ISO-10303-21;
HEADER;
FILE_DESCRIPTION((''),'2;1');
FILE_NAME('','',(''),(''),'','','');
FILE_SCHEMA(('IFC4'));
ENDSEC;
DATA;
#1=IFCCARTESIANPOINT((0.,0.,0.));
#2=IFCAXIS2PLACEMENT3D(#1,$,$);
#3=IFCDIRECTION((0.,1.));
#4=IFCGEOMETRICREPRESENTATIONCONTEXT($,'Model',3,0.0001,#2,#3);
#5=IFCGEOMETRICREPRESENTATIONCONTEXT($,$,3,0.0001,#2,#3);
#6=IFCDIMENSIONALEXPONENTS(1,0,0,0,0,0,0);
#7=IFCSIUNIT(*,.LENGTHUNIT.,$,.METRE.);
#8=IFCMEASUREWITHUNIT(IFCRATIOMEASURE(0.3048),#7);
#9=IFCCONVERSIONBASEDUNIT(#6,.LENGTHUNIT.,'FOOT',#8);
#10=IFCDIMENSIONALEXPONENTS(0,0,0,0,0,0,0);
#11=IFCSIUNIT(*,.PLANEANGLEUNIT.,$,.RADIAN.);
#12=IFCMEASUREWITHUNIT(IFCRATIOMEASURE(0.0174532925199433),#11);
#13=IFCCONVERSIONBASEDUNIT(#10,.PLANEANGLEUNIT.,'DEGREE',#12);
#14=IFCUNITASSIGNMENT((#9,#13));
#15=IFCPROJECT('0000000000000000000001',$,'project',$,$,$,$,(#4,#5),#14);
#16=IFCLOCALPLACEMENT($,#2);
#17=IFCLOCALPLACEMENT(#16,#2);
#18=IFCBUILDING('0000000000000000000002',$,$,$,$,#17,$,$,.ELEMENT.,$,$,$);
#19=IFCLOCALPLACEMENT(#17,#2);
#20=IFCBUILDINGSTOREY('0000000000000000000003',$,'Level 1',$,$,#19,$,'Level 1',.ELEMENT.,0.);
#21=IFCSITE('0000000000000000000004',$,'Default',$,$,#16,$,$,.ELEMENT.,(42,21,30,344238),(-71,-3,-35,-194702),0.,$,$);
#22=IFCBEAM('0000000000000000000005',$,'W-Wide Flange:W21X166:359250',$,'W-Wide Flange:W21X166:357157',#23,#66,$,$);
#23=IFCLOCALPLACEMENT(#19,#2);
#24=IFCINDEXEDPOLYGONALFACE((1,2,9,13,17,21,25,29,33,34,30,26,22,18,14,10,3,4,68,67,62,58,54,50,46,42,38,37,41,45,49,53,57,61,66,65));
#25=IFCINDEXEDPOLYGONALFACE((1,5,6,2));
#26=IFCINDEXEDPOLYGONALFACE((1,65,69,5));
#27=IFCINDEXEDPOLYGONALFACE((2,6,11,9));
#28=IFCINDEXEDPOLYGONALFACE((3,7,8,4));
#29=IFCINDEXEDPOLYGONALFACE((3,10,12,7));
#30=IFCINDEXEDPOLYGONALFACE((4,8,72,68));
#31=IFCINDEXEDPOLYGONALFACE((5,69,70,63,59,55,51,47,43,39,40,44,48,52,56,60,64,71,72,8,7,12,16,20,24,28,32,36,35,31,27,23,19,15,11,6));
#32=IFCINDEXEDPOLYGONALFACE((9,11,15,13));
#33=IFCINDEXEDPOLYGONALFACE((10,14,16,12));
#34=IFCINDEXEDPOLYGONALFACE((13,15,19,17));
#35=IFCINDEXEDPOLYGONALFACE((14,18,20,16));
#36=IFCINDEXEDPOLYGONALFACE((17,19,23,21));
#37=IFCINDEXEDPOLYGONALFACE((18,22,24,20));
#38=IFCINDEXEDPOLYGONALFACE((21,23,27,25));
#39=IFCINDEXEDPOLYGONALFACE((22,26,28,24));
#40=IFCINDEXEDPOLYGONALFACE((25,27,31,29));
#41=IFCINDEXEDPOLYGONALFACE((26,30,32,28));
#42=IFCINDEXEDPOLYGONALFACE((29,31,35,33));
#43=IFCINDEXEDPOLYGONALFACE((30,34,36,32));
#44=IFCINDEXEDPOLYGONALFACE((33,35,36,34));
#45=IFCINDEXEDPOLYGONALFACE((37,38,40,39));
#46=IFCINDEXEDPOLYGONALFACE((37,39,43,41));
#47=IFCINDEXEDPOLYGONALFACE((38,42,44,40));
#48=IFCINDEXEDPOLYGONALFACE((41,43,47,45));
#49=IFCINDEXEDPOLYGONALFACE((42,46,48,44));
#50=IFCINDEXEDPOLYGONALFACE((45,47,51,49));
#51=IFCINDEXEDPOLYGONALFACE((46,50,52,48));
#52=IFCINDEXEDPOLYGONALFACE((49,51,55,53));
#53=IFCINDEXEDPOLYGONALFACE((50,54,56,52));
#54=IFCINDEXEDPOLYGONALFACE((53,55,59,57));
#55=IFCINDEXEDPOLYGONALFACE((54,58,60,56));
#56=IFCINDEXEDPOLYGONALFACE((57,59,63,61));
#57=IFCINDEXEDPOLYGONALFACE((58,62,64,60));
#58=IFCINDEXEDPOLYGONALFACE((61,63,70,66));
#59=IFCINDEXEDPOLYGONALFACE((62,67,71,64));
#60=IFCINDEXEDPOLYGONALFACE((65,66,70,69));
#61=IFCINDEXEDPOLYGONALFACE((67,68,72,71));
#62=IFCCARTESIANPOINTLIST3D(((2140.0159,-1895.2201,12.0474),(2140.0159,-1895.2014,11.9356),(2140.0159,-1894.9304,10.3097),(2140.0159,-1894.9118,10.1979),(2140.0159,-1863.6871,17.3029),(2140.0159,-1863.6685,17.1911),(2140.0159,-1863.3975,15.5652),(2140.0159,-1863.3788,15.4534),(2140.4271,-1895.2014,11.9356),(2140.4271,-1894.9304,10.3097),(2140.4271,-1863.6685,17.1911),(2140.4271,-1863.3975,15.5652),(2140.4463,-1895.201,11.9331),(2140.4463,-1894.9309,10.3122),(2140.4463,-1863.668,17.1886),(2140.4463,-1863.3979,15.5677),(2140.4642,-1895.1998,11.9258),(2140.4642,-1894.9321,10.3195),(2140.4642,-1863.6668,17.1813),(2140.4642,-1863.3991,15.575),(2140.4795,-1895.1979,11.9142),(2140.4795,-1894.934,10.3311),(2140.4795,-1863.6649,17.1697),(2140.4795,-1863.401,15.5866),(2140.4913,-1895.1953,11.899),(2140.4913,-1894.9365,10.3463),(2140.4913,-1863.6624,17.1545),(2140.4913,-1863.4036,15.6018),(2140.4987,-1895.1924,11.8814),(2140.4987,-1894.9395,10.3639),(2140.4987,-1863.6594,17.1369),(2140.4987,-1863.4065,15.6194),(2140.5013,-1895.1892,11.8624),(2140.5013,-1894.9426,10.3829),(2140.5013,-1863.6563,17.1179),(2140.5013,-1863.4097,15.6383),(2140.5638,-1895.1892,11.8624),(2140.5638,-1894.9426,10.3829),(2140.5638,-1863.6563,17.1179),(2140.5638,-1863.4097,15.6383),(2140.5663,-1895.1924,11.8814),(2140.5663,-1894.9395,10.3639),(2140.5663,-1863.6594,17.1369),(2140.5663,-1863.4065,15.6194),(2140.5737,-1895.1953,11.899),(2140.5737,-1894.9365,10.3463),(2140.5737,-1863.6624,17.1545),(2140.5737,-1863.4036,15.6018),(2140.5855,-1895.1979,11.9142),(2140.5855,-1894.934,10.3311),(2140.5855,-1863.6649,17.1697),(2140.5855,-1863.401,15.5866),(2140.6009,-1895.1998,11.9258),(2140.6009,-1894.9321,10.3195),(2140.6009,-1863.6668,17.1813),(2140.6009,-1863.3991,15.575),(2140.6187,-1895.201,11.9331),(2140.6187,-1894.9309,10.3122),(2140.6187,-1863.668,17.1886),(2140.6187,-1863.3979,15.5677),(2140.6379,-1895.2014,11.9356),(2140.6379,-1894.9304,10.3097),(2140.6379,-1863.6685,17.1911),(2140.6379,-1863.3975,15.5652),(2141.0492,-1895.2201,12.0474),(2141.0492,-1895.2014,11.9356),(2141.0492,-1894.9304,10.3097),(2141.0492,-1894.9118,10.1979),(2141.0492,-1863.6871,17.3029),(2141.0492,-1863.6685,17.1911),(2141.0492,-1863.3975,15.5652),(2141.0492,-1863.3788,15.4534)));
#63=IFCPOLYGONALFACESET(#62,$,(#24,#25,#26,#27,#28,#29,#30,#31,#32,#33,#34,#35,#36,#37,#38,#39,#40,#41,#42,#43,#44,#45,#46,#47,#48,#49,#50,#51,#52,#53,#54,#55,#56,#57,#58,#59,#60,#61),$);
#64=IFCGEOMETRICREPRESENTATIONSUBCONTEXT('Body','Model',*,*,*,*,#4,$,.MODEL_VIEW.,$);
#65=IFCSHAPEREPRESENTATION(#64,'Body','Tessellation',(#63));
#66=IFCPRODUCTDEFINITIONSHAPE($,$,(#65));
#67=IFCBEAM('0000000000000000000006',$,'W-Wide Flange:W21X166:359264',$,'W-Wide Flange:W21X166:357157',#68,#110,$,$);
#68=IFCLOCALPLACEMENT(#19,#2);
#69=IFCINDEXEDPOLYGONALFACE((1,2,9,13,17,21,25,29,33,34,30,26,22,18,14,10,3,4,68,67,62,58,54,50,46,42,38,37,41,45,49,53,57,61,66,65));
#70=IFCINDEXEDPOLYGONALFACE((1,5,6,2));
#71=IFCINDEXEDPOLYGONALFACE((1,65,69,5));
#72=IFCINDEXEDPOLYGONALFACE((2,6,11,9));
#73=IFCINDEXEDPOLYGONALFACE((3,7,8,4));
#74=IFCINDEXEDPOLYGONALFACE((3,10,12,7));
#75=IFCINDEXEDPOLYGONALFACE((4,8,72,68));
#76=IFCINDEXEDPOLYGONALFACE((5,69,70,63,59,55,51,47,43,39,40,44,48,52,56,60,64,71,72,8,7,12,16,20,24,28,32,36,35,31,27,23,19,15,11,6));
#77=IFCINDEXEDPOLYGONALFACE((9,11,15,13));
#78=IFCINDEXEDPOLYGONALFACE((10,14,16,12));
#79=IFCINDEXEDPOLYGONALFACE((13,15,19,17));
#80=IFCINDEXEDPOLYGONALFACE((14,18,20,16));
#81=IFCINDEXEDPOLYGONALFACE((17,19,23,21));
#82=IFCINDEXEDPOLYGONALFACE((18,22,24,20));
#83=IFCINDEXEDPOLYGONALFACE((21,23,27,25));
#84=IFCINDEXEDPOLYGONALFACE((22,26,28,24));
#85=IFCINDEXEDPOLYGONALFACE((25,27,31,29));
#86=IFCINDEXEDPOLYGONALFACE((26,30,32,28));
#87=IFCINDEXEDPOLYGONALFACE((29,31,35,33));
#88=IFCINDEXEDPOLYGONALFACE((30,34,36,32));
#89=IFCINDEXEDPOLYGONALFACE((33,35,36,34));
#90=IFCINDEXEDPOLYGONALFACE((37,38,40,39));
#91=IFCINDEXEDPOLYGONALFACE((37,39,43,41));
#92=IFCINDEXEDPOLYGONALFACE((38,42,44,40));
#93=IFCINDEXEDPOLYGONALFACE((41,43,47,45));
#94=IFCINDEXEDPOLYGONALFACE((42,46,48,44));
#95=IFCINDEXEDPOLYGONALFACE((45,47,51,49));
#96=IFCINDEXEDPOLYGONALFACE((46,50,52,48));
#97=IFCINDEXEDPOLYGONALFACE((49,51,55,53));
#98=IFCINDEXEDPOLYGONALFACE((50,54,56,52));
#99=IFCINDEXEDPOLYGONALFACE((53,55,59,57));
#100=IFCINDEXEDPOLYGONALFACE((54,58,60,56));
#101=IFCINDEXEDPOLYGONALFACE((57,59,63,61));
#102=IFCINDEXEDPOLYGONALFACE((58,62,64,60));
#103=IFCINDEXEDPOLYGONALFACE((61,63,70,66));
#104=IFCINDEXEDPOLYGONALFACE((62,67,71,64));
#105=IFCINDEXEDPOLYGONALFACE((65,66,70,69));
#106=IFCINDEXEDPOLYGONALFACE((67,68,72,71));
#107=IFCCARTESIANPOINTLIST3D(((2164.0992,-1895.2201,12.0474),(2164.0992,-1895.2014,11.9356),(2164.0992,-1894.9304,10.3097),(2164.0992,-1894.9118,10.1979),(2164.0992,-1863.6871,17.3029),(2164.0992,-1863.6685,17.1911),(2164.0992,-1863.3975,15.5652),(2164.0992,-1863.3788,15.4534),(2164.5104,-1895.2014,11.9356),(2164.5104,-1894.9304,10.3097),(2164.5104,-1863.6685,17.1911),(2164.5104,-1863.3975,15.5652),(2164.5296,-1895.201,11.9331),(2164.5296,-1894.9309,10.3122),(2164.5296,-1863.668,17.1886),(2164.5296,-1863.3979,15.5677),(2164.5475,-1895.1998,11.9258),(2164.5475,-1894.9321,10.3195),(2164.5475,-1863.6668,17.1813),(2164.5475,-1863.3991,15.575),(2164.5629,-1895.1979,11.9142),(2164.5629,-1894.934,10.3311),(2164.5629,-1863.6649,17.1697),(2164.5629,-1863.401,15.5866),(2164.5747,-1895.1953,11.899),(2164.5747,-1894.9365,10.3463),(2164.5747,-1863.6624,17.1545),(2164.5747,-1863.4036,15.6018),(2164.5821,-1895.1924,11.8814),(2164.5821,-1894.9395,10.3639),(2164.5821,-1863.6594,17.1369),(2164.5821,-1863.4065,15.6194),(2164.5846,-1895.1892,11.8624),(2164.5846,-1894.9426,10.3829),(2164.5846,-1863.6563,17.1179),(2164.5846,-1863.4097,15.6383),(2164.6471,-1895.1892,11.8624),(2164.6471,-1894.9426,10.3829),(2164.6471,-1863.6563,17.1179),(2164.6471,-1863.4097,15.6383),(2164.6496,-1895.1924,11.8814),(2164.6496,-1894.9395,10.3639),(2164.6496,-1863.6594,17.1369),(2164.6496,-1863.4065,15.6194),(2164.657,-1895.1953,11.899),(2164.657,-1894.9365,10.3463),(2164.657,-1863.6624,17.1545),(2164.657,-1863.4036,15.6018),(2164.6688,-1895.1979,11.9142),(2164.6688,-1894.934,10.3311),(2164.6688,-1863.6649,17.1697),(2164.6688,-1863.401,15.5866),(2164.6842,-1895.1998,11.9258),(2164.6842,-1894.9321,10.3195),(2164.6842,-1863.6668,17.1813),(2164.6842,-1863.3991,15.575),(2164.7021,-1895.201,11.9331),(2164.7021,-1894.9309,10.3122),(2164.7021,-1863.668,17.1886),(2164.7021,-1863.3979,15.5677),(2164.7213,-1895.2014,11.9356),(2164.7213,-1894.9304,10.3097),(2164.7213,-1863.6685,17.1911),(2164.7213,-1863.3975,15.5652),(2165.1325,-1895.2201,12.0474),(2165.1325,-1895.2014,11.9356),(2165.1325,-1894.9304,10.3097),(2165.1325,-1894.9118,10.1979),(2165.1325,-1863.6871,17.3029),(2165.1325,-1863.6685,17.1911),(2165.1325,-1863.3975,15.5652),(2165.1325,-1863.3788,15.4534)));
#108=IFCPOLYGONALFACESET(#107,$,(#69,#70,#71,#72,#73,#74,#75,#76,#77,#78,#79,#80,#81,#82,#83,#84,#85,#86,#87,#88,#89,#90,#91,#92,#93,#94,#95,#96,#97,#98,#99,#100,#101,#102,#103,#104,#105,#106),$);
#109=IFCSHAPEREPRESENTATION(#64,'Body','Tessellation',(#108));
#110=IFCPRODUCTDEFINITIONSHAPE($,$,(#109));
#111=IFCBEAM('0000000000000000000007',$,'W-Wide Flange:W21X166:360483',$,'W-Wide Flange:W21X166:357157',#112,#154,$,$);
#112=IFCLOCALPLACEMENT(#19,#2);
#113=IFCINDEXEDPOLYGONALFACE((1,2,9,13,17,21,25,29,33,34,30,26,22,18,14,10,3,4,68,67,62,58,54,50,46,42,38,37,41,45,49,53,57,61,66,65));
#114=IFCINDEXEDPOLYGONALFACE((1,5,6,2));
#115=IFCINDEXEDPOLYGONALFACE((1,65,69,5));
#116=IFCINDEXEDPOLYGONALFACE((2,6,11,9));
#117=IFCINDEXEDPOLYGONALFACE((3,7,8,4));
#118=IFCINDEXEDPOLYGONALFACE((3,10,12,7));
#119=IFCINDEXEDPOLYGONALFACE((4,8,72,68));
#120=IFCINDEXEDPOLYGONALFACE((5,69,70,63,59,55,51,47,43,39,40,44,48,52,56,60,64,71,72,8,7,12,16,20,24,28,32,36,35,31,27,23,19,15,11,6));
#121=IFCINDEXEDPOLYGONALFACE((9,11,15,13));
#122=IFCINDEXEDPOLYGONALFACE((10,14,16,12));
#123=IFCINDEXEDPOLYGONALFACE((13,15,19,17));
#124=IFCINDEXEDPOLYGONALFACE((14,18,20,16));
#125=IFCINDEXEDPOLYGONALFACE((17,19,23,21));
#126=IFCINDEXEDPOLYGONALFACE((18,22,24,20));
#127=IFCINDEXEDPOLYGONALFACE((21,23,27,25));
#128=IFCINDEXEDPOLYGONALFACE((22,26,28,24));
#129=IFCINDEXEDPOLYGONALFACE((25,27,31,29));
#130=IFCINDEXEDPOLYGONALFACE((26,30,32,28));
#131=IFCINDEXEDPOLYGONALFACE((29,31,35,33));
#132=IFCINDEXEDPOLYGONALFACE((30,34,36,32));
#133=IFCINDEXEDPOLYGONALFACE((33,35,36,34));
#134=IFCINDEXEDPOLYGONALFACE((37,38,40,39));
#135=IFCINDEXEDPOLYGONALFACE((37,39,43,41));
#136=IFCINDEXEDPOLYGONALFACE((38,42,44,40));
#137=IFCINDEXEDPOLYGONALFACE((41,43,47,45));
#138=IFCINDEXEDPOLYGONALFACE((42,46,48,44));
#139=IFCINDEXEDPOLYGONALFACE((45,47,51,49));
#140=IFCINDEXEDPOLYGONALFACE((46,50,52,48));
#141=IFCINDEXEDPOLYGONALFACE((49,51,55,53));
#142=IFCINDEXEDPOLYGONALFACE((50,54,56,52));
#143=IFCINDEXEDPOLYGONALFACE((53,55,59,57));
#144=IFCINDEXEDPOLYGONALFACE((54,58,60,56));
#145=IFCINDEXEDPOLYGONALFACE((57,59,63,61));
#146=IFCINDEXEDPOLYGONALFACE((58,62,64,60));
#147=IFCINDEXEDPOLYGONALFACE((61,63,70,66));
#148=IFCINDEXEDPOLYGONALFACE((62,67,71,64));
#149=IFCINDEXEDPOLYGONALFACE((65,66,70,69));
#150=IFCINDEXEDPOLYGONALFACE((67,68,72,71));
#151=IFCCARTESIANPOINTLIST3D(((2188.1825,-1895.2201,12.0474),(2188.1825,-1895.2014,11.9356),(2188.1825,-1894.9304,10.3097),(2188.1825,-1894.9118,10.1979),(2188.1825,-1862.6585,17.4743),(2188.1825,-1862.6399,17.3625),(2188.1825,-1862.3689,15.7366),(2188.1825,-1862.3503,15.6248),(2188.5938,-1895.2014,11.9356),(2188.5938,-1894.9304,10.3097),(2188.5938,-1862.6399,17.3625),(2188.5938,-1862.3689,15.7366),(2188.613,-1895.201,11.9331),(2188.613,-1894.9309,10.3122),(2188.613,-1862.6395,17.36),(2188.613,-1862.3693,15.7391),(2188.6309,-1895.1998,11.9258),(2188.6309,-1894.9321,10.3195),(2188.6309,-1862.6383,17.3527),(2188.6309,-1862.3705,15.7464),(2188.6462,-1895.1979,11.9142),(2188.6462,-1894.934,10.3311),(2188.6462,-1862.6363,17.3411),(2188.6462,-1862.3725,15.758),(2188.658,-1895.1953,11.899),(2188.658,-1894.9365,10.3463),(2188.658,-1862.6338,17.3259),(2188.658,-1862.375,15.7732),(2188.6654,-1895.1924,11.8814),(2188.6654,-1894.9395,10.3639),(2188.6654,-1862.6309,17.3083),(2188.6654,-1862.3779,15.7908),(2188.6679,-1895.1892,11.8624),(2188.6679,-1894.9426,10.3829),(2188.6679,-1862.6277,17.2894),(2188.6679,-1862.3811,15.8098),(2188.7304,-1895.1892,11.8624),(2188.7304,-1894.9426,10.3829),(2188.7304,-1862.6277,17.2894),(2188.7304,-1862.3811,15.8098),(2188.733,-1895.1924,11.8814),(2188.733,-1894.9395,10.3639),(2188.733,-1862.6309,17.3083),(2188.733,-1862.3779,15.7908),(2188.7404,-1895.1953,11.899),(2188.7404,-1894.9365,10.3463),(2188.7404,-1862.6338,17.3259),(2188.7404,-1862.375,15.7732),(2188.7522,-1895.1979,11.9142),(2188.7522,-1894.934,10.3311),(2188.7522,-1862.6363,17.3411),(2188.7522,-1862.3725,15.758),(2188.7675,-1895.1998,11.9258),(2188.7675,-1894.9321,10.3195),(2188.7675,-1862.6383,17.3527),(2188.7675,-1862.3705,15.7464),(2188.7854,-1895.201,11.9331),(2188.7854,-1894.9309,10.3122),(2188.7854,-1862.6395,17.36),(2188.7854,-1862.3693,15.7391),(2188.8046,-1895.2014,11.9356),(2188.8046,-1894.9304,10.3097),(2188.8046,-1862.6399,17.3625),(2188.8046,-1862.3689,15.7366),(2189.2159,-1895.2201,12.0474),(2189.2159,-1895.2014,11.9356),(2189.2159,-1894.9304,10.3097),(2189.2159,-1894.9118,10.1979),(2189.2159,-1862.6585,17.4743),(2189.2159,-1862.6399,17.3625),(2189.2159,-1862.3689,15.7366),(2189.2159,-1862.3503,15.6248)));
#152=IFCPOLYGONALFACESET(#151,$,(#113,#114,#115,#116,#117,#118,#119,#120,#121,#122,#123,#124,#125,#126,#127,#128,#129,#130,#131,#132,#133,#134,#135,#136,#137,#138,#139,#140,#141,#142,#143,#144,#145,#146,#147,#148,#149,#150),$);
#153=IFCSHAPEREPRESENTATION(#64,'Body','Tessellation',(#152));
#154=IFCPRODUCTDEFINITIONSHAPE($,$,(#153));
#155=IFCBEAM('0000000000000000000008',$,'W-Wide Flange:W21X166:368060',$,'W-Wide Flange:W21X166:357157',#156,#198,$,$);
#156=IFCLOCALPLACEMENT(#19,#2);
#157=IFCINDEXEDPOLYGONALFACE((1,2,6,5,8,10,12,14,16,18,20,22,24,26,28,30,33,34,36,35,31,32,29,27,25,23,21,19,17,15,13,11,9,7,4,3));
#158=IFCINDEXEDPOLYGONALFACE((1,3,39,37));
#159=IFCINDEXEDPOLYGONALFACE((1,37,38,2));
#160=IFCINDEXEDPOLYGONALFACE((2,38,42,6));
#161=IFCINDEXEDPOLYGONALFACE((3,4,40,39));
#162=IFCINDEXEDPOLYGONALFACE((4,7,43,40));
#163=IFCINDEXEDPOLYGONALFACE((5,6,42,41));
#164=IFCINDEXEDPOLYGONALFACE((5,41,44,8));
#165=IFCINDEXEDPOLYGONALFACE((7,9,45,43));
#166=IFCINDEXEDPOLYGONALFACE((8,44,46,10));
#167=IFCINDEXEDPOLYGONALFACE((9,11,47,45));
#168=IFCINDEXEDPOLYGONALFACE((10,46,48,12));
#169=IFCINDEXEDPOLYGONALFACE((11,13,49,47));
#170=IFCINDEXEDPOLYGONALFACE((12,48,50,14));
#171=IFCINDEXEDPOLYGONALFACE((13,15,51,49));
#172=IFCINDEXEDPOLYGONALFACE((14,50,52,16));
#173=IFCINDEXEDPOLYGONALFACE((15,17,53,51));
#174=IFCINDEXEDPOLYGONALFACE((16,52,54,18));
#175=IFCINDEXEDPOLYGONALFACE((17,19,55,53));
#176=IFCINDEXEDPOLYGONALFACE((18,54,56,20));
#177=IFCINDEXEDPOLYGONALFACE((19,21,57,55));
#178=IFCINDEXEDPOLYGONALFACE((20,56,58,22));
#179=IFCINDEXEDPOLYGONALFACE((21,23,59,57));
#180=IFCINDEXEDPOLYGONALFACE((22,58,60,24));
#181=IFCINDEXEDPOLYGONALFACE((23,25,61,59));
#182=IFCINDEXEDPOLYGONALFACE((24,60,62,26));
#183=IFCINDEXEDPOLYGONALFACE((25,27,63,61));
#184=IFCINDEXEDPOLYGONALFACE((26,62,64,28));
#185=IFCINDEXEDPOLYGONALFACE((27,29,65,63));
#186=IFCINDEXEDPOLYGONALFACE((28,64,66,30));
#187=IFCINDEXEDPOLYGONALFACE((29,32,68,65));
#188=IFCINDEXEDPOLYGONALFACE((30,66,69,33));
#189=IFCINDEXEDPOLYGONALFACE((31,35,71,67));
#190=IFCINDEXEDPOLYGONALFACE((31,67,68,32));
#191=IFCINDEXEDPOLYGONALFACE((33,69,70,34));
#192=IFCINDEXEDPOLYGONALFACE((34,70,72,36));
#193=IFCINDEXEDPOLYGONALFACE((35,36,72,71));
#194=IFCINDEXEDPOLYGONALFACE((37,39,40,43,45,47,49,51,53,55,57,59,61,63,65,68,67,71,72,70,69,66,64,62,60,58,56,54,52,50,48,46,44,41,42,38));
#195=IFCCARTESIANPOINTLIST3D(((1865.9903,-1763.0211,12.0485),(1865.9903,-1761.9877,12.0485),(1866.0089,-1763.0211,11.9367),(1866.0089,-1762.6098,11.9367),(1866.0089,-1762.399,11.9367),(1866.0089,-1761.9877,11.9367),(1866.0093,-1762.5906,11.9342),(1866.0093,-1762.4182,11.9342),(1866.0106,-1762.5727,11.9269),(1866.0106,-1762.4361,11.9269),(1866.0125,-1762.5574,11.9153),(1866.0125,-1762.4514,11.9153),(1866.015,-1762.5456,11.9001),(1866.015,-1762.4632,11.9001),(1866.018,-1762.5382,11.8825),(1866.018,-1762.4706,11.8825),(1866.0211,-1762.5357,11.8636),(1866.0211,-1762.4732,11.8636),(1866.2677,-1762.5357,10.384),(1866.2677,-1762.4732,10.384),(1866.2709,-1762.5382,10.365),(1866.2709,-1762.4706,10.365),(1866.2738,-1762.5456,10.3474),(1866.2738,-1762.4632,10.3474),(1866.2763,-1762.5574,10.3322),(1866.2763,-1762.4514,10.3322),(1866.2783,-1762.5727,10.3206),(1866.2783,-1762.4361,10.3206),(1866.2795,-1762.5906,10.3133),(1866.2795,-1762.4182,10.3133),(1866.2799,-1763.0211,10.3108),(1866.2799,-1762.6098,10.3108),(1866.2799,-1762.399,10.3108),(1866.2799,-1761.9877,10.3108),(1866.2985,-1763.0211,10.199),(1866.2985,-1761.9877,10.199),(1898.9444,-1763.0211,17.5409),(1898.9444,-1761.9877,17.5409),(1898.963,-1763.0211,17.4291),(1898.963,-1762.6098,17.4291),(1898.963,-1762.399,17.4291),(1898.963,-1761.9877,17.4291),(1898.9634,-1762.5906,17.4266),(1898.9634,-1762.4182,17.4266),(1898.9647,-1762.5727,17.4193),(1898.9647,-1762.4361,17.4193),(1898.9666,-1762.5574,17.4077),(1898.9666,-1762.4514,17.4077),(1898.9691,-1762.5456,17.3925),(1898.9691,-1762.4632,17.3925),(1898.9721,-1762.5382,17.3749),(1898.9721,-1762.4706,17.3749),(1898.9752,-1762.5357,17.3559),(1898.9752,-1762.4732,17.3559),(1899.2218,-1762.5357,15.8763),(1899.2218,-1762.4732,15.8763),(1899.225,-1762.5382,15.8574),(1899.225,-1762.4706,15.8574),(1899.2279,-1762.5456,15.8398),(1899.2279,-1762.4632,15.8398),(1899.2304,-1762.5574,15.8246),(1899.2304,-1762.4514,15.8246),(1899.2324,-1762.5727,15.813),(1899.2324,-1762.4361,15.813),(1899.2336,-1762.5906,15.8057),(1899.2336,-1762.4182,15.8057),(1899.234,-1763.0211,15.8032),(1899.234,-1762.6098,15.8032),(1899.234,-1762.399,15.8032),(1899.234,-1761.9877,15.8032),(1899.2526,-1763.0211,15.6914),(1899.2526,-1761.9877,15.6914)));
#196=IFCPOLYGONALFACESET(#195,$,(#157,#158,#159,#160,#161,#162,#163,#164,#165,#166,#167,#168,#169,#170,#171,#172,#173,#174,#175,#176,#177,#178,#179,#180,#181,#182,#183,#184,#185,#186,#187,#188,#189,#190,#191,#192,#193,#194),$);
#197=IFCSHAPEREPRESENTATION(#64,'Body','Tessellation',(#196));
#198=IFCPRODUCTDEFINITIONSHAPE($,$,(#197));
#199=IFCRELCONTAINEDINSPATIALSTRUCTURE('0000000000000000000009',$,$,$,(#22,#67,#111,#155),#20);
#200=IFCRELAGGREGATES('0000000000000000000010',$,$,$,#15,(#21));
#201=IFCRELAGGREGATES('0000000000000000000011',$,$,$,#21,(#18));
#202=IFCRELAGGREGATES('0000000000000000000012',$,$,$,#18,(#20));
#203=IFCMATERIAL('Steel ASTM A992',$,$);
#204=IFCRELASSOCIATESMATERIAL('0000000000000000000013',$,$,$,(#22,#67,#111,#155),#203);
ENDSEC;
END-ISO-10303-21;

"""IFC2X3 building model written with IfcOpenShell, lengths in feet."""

from ifc_helpers import new_model, entity, si_unit, converted_unit, direction, frame, frame_2d, origin, place, context, subcontext, project, spatial, i_section, extrude, material, element, save


model = new_model("IFC2X3")

# Units and contexts
model_context = context("Model", 3, precision=0.0001, world=origin(), true_north=direction((0.0, 1.0)))
context_of_model = context(None, 3, precision=0.0001, world=origin(), true_north=direction((0.0, 1.0)))
body_context = subcontext(model_context, "Body", "Model", "MODEL_VIEW")
ifc_project = project(units=[converted_unit("LENGTHUNIT", "FOOT", entity("IfcRatioMeasure", 0.3048), si_unit("LENGTHUNIT", "METRE"), dimensions=[1, 0, 0, 0, 0, 0, 0]), converted_unit("PLANEANGLEUNIT", "DEGREE", entity("IfcRatioMeasure", 0.0174532925199433), si_unit("PLANEANGLEUNIT", "RADIAN"), dimensions=[0, 0, 0, 0, 0, 0, 0])], contexts=[model_context, context_of_model])

# Site, building, storey
site_placement = place(None, origin())
site = spatial("IfcSite", under=ifc_project, at=site_placement, Name="Default", CompositionType="ELEMENT", RefLatitude=(42, 21, 30, 344238), RefLongitude=(-71, -3, -35, -194702), RefElevation=0.0)
building_placement = place(site_placement, origin())
building = spatial("IfcBuilding", under=site, at=building_placement, CompositionType="ELEMENT")
storey_placement = place(building_placement, origin())
storey = spatial("IfcBuildingStorey", under=building, at=storey_placement, Name="Level 1", LongName="Level 1", CompositionType="ELEMENT", Elevation=0.0)

# Beams
ifc_material_1 = material(Name="Steel ASTM A992")
beam_1_placement = place(storey_placement, frame((2140.5325, -1895.6585, 11.9743), z_axis=(0.0, -0.164399, 0.986394), x_axis=(0.0, 0.986394, 0.164399)))
element("IfcBeam", 1, at=beam_1_placement, inside=storey, material=ifc_material_1, Name="W-Wide Flange:W21X166:359250", ObjectType="W-Wide Flange:W21X166:357157", context=body_context, shape_type="SweptSolid", body=[
    extrude(i_section(OverallWidth=1.0333, OverallDepth=1.875, WebThickness=0.0625, FlangeThickness=0.1133, FilletRadius=0.0742, at=frame_2d((0.0, 0.0), x_axis=(0.0, 1.0))), frame((0.4445, 0.0, -0.9375), z_axis=(1.0, 0.0, 0.0), x_axis=(0.0, 0.0, -1.0)), (0.0, 0.0, 1.0), 31.9679),
])
beam_2_placement = place(storey_placement, frame((2164.6159, -1895.6585, 11.9743), z_axis=(0.0, -0.164399, 0.986394), x_axis=(0.0, 0.986394, 0.164399)))
element("IfcBeam", 2, at=beam_2_placement, inside=storey, material=ifc_material_1, Name="W-Wide Flange:W21X166:359264", ObjectType="W-Wide Flange:W21X166:357157", context=body_context, shape_type="SweptSolid", body=[
    extrude(i_section(OverallWidth=1.0333, OverallDepth=1.875, WebThickness=0.0625, FlangeThickness=0.1133, FilletRadius=0.0742, at=frame_2d((0.0, 0.0), x_axis=(0.0, 1.0))), frame((0.4445, 0.0, -0.9375), z_axis=(1.0, 0.0, 0.0), x_axis=(0.0, 0.0, -1.0)), (0.0, 0.0, 1.0), 31.9679),
])
beam_3_placement = place(storey_placement, frame((2188.6992, -1895.6585, 11.9743), z_axis=(0.0, -0.164399, 0.986394), x_axis=(0.0, 0.986394, 0.164399)))
element("IfcBeam", 3, at=beam_3_placement, inside=storey, material=ifc_material_1, Name="W-Wide Flange:W21X166:360483", ObjectType="W-Wide Flange:W21X166:357157", context=body_context, shape_type="SweptSolid", body=[
    extrude(i_section(OverallWidth=1.0333, OverallDepth=1.875, WebThickness=0.0625, FlangeThickness=0.1133, FilletRadius=0.0742, at=frame_2d((0.0, 0.0), x_axis=(0.0, 1.0))), frame((0.4445, 0.0, -0.9375), z_axis=(1.0, 0.0, 0.0), x_axis=(0.0, 0.0, -1.0)), (0.0, 0.0, 1.0), 33.0107),
])

# Beam
beam_4_placement = place(storey_placement, frame((1865.8276, -1762.5044, 12.0214), z_axis=(-0.164399, 0.0, 0.986394), x_axis=(0.986394, 0.0, 0.164399)))
element("IfcBeam", 4, at=beam_4_placement, inside=storey, material=ifc_material_1, Name="W-Wide Flange:W21X166:368060", ObjectType="W-Wide Flange:W21X166:357157", context=body_context, shape_type="SweptSolid", body=[
    extrude(i_section(OverallWidth=1.0333, OverallDepth=1.875, WebThickness=0.0625, FlangeThickness=0.1133, FilletRadius=0.0742, at=frame_2d((0.0, 0.0), x_axis=(0.0, 1.0))), frame((0.165, 0.0, -0.9375), z_axis=(1.0, 0.0, 0.0), x_axis=(0.0, 0.0, -1.0)), (0.0, 0.0, 1.0), 33.4087),
])

save(model, "model.ifc")
